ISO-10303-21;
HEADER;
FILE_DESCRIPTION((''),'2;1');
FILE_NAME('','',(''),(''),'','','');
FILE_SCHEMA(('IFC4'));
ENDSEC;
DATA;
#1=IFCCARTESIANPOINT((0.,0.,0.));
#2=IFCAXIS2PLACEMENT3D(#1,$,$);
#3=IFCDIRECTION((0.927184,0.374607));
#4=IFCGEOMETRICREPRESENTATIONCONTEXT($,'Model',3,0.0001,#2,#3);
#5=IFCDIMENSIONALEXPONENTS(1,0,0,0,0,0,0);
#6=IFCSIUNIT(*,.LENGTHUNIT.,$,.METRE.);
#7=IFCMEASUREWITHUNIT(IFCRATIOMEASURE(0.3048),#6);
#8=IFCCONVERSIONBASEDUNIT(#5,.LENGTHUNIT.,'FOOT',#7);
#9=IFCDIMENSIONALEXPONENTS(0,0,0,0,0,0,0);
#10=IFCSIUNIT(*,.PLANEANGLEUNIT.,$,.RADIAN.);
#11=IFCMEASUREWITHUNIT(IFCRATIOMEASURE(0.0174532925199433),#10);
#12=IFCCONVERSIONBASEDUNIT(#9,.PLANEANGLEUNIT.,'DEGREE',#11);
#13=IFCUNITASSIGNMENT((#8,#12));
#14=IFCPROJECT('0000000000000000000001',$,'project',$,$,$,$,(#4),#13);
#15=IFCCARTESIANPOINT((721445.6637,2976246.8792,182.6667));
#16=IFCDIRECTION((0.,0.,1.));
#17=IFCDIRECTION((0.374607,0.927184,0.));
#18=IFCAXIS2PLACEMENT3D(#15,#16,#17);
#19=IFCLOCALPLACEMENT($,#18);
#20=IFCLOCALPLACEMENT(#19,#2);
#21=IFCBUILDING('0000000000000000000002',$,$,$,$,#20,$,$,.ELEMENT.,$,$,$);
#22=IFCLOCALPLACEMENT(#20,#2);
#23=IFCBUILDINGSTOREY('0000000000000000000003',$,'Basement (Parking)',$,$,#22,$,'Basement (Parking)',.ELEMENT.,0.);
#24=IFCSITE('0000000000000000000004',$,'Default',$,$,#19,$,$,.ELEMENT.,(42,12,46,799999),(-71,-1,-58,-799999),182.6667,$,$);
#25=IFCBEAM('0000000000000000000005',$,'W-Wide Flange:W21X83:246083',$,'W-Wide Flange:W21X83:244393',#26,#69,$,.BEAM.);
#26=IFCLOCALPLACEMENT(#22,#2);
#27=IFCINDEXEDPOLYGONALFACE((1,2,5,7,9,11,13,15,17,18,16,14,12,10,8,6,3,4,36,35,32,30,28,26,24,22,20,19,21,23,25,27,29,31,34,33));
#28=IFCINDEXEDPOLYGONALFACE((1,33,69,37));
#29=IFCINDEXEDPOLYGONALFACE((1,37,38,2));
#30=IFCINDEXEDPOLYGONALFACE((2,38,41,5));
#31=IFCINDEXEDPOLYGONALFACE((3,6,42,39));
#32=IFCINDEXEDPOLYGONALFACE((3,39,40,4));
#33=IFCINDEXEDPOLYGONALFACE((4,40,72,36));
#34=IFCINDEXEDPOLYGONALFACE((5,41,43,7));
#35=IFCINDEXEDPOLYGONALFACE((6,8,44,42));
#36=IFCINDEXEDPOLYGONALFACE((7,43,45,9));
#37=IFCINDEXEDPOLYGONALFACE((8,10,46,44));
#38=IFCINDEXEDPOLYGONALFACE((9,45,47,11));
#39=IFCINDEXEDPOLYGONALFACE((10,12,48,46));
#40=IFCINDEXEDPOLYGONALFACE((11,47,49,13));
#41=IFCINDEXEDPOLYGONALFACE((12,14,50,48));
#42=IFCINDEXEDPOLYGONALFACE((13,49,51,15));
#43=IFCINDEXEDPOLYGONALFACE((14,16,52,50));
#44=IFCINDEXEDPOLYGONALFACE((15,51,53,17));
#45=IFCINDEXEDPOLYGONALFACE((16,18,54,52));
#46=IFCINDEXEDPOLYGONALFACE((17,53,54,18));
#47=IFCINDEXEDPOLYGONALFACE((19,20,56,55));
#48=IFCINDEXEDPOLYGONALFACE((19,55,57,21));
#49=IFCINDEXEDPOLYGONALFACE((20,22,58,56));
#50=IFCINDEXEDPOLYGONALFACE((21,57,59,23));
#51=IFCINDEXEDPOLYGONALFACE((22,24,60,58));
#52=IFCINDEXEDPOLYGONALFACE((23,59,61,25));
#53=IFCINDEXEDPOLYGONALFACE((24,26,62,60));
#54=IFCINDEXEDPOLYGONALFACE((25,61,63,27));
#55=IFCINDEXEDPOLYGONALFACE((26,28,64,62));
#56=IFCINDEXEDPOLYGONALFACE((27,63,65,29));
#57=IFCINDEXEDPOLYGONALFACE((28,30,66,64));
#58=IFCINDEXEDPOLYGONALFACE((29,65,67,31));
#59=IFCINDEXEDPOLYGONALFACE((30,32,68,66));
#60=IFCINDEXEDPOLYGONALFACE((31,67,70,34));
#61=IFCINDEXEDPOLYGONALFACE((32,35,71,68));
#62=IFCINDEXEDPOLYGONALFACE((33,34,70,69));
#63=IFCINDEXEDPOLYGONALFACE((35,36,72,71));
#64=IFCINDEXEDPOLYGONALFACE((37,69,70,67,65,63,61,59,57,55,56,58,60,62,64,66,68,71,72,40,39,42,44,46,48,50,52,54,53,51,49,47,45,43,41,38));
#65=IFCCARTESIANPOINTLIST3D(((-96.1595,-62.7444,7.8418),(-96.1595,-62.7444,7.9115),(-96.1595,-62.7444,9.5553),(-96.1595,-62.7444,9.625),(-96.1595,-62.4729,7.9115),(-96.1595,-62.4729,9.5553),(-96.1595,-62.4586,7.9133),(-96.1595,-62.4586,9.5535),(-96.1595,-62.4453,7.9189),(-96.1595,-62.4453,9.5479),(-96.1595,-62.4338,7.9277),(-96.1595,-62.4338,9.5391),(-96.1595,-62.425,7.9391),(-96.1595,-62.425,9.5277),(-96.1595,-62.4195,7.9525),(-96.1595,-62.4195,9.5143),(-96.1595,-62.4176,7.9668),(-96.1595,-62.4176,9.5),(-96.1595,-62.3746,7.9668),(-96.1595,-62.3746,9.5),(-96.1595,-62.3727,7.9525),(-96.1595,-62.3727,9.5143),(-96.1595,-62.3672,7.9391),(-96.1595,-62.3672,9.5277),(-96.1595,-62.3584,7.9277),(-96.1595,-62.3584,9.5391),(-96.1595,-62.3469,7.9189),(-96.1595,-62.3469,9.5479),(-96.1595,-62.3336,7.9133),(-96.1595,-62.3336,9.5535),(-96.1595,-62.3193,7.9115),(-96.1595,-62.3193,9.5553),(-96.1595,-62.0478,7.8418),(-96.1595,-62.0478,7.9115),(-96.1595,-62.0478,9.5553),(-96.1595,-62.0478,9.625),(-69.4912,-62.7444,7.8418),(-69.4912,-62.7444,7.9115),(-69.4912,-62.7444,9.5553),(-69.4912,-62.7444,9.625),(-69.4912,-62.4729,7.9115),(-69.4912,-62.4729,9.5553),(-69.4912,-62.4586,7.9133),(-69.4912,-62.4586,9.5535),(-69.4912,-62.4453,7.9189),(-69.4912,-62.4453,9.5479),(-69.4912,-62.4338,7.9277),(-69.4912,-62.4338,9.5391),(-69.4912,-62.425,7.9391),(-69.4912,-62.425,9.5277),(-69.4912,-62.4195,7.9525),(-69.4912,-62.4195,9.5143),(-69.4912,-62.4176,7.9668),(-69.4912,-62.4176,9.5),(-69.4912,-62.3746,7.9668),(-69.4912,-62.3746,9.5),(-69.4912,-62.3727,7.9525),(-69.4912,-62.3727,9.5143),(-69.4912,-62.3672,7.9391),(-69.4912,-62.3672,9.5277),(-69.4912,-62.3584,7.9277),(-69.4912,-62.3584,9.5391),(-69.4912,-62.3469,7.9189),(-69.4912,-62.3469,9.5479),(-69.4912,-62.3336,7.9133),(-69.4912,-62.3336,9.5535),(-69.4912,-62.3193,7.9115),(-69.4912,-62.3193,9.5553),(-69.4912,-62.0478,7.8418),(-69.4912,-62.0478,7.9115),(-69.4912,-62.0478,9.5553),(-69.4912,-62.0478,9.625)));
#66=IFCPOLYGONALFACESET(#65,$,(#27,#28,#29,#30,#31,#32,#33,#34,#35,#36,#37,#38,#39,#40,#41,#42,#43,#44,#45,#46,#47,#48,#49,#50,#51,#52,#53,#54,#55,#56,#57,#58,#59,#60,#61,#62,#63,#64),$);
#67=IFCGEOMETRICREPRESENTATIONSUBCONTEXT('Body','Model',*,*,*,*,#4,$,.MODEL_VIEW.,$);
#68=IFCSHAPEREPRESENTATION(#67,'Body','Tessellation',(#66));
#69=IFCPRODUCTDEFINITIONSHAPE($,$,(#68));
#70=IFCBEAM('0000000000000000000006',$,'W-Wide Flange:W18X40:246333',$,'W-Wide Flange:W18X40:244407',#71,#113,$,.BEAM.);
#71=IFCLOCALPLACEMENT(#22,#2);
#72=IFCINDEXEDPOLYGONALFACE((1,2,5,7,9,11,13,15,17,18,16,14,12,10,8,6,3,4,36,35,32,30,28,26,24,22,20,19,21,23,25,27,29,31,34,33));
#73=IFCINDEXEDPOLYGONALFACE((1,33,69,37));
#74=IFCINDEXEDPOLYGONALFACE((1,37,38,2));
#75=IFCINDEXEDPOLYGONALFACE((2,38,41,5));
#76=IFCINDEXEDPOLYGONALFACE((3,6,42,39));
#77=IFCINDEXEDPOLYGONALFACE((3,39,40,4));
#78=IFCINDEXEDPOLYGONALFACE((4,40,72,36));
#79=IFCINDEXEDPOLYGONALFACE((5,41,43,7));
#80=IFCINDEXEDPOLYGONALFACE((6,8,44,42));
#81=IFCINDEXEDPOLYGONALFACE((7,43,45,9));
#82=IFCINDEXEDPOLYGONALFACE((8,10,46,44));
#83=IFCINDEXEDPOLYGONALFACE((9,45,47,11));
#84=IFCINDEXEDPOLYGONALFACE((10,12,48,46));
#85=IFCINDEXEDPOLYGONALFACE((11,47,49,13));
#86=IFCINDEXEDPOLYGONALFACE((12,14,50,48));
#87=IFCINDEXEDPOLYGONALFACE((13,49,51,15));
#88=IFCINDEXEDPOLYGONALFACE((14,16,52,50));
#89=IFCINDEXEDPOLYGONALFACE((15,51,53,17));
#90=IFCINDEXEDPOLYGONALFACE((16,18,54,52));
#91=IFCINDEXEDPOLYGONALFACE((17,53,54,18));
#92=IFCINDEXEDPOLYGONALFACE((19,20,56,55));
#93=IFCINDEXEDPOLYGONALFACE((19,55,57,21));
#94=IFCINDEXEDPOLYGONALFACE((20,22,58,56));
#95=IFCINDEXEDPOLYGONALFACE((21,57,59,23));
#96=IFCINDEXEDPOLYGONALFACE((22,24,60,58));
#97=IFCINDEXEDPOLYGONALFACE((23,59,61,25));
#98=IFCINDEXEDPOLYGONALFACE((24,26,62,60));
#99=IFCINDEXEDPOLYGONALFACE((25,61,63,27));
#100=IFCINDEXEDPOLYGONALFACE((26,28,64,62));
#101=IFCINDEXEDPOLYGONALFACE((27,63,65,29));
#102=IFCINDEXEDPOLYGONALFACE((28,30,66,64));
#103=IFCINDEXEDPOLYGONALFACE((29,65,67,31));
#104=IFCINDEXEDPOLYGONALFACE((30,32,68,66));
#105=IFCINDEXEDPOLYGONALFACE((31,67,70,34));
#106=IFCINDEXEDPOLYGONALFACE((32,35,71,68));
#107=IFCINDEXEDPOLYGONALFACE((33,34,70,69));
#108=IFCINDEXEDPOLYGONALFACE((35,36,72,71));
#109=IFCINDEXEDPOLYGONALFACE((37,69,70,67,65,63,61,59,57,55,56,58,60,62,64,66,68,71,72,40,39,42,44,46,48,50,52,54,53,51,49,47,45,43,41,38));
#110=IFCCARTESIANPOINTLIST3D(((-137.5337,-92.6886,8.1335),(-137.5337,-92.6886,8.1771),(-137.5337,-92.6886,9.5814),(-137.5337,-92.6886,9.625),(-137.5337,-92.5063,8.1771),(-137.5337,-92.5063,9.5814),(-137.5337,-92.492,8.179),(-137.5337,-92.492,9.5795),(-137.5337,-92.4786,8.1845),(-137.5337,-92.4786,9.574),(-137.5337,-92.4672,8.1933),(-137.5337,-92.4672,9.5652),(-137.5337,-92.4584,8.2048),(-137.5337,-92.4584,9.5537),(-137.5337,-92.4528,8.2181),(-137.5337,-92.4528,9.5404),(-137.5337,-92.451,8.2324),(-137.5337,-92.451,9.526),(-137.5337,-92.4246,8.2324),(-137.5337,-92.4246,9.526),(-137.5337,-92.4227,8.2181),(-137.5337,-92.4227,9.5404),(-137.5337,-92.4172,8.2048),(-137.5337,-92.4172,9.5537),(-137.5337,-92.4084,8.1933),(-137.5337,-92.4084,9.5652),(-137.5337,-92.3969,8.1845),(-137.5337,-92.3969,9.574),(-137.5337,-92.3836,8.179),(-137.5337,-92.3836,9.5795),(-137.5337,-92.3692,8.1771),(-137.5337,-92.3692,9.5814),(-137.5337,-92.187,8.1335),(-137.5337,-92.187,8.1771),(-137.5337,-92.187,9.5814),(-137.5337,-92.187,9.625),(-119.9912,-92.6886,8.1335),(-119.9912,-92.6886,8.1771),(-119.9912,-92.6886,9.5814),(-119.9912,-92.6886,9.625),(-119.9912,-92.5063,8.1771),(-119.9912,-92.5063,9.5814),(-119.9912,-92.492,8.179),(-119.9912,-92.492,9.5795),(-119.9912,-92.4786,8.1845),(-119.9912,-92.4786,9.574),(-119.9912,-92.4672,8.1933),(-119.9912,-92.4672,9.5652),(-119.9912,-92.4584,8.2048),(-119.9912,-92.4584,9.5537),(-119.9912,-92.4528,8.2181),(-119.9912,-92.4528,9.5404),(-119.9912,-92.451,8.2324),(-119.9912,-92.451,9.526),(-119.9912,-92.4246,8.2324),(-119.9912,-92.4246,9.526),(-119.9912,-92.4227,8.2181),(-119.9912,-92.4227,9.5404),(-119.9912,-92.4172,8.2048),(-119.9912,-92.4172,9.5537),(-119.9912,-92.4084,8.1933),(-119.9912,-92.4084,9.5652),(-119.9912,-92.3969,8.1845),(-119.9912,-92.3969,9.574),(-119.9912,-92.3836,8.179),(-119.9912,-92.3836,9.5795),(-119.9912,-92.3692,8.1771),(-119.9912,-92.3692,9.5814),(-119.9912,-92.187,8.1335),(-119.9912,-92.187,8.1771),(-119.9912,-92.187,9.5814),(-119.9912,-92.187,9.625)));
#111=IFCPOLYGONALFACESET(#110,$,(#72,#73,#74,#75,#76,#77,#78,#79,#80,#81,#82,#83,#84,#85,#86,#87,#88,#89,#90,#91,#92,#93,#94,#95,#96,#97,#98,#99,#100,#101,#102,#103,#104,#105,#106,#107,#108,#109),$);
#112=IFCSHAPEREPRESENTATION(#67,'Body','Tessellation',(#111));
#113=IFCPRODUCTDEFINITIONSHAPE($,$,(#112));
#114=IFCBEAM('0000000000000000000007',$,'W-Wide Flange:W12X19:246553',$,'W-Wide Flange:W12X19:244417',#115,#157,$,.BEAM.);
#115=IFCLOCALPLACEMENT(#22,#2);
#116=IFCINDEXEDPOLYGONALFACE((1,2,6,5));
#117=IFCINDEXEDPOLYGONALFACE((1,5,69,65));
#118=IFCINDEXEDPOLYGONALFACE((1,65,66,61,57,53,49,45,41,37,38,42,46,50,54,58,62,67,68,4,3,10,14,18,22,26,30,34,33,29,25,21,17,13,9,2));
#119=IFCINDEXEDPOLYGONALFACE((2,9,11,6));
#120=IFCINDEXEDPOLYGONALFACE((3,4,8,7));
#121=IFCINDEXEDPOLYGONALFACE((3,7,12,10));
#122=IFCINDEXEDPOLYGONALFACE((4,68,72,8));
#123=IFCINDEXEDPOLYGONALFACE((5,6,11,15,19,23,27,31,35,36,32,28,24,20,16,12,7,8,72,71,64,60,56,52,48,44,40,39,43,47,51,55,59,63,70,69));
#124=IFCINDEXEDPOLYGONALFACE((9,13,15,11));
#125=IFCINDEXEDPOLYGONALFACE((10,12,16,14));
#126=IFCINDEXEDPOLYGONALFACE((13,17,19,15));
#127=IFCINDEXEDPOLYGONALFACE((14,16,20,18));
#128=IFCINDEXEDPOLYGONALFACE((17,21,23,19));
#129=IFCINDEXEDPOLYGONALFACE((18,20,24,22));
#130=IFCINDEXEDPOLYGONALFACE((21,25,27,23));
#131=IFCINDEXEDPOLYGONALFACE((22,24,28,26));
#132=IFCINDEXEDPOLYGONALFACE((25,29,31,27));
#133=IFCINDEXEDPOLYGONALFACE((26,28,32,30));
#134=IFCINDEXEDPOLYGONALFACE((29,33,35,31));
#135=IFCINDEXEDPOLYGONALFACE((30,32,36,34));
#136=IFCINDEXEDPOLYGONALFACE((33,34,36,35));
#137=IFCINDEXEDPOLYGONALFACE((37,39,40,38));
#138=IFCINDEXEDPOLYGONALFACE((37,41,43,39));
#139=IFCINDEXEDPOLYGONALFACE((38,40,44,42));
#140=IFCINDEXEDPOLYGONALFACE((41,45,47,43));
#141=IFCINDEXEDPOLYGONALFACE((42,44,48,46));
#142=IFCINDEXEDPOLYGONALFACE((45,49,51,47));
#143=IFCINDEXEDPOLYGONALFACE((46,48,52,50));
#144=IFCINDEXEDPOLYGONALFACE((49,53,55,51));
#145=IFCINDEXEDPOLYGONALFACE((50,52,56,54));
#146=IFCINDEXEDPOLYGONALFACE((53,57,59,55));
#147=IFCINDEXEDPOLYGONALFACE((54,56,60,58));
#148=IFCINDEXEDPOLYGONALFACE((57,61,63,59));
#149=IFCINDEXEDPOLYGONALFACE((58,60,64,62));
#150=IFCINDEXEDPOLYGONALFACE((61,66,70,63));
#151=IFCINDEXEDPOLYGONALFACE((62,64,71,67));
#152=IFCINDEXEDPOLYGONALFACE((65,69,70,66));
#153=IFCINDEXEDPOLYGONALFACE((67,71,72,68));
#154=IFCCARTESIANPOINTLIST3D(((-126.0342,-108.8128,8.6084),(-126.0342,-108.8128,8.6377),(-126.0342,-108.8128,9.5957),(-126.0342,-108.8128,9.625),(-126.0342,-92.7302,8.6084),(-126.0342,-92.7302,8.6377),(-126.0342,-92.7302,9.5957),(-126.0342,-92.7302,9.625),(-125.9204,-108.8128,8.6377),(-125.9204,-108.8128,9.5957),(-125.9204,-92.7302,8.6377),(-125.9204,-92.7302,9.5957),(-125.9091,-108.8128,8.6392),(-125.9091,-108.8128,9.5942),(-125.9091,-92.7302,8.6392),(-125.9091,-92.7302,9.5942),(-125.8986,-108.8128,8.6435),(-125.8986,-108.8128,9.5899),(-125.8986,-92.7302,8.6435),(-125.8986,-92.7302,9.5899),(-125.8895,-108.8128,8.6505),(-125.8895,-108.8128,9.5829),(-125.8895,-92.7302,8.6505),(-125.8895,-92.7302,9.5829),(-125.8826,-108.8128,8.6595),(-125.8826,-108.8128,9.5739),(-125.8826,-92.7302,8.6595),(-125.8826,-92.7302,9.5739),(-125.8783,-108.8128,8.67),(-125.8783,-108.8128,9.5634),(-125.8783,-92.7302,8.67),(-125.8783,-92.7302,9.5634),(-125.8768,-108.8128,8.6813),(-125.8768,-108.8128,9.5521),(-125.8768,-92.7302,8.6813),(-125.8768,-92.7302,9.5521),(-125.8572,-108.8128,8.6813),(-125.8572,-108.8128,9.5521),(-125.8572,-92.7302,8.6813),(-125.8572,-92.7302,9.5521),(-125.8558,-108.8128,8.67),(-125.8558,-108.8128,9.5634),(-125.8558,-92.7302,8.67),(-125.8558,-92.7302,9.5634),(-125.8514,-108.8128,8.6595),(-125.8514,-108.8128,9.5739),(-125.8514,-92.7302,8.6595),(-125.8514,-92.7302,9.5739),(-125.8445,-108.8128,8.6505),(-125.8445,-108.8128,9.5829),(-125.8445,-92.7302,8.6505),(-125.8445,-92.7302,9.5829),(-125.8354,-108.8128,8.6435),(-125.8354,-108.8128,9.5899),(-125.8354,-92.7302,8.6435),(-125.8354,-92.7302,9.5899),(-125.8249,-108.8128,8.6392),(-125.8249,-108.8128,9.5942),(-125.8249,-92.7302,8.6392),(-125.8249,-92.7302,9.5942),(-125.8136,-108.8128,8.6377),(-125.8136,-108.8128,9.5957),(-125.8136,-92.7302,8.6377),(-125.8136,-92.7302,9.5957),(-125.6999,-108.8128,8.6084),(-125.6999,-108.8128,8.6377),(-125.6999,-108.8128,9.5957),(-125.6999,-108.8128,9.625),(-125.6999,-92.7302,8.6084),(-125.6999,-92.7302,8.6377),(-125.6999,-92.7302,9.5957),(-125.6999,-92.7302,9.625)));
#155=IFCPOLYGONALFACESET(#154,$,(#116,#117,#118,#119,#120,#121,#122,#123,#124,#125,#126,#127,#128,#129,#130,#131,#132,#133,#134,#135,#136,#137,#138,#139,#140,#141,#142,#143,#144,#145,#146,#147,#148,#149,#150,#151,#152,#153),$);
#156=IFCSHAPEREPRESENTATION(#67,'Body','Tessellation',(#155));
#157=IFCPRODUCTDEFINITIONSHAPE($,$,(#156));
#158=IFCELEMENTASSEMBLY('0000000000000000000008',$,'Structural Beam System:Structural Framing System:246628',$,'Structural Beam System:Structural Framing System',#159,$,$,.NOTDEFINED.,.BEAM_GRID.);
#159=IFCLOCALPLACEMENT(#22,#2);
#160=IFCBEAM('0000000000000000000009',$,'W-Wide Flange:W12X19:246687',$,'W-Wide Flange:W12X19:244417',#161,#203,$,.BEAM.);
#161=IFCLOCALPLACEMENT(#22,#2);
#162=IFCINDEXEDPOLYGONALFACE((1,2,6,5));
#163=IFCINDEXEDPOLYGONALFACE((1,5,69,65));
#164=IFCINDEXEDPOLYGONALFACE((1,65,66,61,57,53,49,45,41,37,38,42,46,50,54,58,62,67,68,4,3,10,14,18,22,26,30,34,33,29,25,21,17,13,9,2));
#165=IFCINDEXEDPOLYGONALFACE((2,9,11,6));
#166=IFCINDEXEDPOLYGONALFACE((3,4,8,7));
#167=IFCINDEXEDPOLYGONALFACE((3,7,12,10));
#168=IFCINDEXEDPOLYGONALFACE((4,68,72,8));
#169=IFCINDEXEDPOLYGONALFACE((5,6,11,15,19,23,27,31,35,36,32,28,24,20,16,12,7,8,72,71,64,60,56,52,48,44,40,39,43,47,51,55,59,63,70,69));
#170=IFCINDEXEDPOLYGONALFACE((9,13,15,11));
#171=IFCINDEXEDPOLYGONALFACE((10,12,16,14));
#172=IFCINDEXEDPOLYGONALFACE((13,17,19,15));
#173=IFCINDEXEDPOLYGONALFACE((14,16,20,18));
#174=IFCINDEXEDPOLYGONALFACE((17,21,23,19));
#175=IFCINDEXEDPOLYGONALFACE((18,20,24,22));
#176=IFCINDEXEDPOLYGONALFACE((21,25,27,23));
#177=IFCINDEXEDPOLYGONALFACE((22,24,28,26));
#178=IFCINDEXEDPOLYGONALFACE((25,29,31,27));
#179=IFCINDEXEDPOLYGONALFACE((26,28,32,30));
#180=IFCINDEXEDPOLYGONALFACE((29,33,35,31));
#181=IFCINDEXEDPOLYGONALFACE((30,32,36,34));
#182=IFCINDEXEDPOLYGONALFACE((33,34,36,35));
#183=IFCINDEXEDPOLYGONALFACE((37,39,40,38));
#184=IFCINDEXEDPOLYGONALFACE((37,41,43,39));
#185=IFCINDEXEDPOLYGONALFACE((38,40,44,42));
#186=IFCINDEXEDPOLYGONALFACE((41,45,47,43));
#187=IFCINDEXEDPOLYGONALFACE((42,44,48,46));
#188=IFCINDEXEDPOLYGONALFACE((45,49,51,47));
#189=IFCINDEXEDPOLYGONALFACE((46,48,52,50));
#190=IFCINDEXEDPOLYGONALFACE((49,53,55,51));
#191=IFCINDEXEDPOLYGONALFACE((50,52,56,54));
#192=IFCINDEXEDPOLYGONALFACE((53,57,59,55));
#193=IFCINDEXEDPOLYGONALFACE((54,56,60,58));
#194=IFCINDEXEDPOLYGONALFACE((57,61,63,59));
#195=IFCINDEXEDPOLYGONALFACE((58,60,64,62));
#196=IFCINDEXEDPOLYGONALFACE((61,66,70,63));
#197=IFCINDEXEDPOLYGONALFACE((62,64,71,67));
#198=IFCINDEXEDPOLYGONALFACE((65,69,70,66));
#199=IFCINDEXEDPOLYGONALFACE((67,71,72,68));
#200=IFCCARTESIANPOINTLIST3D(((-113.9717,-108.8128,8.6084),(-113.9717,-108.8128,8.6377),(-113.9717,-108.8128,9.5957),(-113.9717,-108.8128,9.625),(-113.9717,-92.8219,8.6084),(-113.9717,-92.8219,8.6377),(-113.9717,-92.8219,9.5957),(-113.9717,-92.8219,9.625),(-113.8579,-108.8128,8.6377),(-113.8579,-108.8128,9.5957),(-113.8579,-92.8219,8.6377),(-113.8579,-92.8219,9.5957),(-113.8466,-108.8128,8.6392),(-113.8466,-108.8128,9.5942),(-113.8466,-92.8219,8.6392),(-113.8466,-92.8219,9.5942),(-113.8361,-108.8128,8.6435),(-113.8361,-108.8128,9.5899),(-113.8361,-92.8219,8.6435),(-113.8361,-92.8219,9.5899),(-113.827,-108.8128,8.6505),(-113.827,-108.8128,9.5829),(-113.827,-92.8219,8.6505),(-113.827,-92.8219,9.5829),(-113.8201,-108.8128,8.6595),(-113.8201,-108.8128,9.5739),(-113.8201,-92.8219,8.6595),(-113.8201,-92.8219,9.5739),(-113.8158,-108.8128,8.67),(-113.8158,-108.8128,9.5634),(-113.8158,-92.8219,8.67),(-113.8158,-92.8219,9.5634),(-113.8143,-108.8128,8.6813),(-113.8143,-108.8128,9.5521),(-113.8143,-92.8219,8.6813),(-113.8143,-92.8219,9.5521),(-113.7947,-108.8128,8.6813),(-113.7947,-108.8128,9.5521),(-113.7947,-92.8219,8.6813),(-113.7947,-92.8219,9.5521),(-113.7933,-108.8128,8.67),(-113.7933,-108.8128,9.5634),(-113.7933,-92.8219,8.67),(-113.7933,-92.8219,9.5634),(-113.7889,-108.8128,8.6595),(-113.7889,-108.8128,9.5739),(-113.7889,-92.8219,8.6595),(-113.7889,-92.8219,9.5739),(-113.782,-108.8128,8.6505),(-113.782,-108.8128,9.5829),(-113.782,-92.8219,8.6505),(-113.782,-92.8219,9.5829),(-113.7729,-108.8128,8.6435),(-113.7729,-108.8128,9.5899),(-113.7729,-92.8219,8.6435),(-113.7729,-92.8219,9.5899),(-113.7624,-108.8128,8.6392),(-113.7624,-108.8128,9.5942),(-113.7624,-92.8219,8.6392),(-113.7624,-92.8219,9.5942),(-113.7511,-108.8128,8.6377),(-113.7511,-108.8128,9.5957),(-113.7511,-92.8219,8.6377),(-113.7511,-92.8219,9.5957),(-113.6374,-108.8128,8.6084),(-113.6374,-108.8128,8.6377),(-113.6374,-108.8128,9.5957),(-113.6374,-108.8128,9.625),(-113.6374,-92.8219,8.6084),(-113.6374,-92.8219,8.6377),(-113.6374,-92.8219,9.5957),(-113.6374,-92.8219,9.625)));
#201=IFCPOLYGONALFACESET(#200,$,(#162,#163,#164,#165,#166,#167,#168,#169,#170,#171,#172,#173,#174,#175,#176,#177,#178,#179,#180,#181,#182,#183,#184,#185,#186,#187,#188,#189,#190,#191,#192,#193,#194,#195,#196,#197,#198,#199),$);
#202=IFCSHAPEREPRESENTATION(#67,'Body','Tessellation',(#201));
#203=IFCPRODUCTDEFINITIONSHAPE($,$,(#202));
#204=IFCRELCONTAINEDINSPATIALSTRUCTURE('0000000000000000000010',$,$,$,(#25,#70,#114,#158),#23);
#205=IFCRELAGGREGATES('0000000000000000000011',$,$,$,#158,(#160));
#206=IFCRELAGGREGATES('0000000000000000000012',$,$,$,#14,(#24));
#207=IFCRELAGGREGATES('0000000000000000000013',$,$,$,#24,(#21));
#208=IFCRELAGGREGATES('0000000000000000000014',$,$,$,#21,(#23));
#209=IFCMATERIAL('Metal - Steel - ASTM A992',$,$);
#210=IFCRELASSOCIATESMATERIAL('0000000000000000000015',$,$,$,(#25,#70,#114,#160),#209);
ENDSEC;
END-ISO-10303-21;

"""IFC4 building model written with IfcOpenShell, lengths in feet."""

from ifc_helpers import new_model, entity, si_unit, converted_unit, direction, frame, frame_2d, origin, place, context, subcontext, project, spatial, i_section, extrude, material, element, aggregate, save


model = new_model("IFC4")

# Units and contexts
model_context = context("Model", 3, precision=0.0001, world=origin(), true_north=direction((0.927184, 0.374607)))
body_context = subcontext(model_context, "Body", "Model", "MODEL_VIEW")
ifc_project = project(units=[converted_unit("LENGTHUNIT", "FOOT", entity("IfcRatioMeasure", 0.3048), si_unit("LENGTHUNIT", "METRE"), dimensions=[1, 0, 0, 0, 0, 0, 0]), converted_unit("PLANEANGLEUNIT", "DEGREE", entity("IfcRatioMeasure", 0.0174532925199433), si_unit("PLANEANGLEUNIT", "RADIAN"), dimensions=[0, 0, 0, 0, 0, 0, 0])], contexts=[model_context])

# Site, building, storey
site_placement = place(None, frame((721445.6637, 2976246.8792, 182.6667), z_axis=(0.0, 0.0, 1.0), x_axis=(0.374607, 0.927184, 0.0)))
site = spatial("IfcSite", under=ifc_project, at=site_placement, Name="Default", CompositionType="ELEMENT", RefLatitude=(42, 12, 46, 799999), RefLongitude=(-71, -1, -58, -799999), RefElevation=182.6667)
building_placement = place(site_placement, origin())
building = spatial("IfcBuilding", under=site, at=building_placement, CompositionType="ELEMENT")
storey_placement = place(building_placement, origin())
storey = spatial("IfcBuildingStorey", under=building, at=storey_placement, Name="Basement (Parking)", LongName="Basement (Parking)", CompositionType="ELEMENT", Elevation=0.0)

# Shared definitions
ifc_material_1 = material(Name="Metal - Steel - ASTM A992")

# Beams
beam_1_placement = place(storey_placement, frame((-96.617, -62.3961, 9.625)))
element("IfcBeam", 1, at=beam_1_placement, inside=storey, material=ifc_material_1, Name="W-Wide Flange:W21X83:246083", ObjectType="W-Wide Flange:W21X83:244393", PredefinedType="BEAM", context=body_context, shape_type="SweptSolid", body=[
    extrude(i_section(OverallWidth=0.6966, OverallDepth=1.7832, WebThickness=0.043, FlangeThickness=0.0697, FilletRadius=0.0553, at=frame_2d((0.0, 0.0), x_axis=(0.0, 1.0))), frame((0.4575, 0.0, -0.8916), z_axis=(1.0, 0.0, 0.0), x_axis=(0.0, 0.0, -1.0)), (0.0, 0.0, 1.0), 26.6683),
])
beam_2_placement = place(storey_placement, frame((-119.5337, -92.4378, 9.625), z_axis=(0.0, 0.0, 1.0), x_axis=(-1.0, 0.0, 0.0)))
element("IfcBeam", 2, at=beam_2_placement, inside=storey, material=ifc_material_1, Name="W-Wide Flange:W18X40:246333", ObjectType="W-Wide Flange:W18X40:244407", PredefinedType="BEAM", context=body_context, shape_type="SweptSolid", body=[
    extrude(i_section(OverallWidth=0.5016, OverallDepth=1.4915, WebThickness=0.0264, FlangeThickness=0.0436, FilletRadius=0.0553, at=frame_2d((0.0, 0.0), x_axis=(0.0, 1.0))), frame((0.4575, 0.0, -0.7458), z_axis=(1.0, 0.0, 0.0), x_axis=(0.0, 0.0, -1.0)), (0.0, 0.0, 1.0), 17.5425),
])
beam_3_placement = place(storey_placement, frame((-125.867, -92.4378, 9.625), z_axis=(0.0, 0.0, 1.0), x_axis=(0.0, -1.0, 0.0)))
element("IfcBeam", 3, at=beam_3_placement, inside=storey, material=ifc_material_1, Name="W-Wide Flange:W12X19:246553", ObjectType="W-Wide Flange:W12X19:244417", PredefinedType="BEAM", context=body_context, shape_type="SweptSolid", body=[
    extrude(i_section(OverallWidth=0.3343, OverallDepth=1.0166, WebThickness=0.0195, FlangeThickness=0.0293, FilletRadius=0.0436, at=frame_2d((0.0, 0.0), x_axis=(0.0, 1.0))), frame((0.2925, 0.0, -0.5083), z_axis=(1.0, 0.0, 0.0), x_axis=(0.0, 0.0, -1.0)), (0.0, 0.0, 1.0), 16.0825),
])

# Element assembly, beam
assembly_placement = place(storey_placement, origin())
assembly = element("IfcElementAssembly", 4, at=assembly_placement, inside=storey, Name="Structural Beam System:Structural Framing System:246628", ObjectType="Structural Beam System:Structural Framing System", AssemblyPlace="NOTDEFINED", PredefinedType="BEAM_GRID")
beam_4_placement = place(assembly_placement, frame((-113.8045, -92.4378, 9.625), z_axis=(0.0, 0.0, 1.0), x_axis=(0.0, -1.0, 0.0)))
beam_4 = element("IfcBeam", 5, at=beam_4_placement, material=ifc_material_1, Name="W-Wide Flange:W12X19:246687", ObjectType="W-Wide Flange:W12X19:244417", PredefinedType="BEAM", context=body_context, shape_type="SweptSolid", body=[
    extrude(i_section(OverallWidth=0.3343, OverallDepth=1.0166, WebThickness=0.0195, FlangeThickness=0.0293, FilletRadius=0.0436, at=frame_2d((0.0, 0.0), x_axis=(0.0, 1.0))), frame((0.3841, 0.0, -0.5083), z_axis=(1.0, 0.0, 0.0), x_axis=(0.0, 0.0, -1.0)), (0.0, 0.0, 1.0), 15.9909),
])
aggregate(assembly, [beam_4])

save(model, "model.ifc")
